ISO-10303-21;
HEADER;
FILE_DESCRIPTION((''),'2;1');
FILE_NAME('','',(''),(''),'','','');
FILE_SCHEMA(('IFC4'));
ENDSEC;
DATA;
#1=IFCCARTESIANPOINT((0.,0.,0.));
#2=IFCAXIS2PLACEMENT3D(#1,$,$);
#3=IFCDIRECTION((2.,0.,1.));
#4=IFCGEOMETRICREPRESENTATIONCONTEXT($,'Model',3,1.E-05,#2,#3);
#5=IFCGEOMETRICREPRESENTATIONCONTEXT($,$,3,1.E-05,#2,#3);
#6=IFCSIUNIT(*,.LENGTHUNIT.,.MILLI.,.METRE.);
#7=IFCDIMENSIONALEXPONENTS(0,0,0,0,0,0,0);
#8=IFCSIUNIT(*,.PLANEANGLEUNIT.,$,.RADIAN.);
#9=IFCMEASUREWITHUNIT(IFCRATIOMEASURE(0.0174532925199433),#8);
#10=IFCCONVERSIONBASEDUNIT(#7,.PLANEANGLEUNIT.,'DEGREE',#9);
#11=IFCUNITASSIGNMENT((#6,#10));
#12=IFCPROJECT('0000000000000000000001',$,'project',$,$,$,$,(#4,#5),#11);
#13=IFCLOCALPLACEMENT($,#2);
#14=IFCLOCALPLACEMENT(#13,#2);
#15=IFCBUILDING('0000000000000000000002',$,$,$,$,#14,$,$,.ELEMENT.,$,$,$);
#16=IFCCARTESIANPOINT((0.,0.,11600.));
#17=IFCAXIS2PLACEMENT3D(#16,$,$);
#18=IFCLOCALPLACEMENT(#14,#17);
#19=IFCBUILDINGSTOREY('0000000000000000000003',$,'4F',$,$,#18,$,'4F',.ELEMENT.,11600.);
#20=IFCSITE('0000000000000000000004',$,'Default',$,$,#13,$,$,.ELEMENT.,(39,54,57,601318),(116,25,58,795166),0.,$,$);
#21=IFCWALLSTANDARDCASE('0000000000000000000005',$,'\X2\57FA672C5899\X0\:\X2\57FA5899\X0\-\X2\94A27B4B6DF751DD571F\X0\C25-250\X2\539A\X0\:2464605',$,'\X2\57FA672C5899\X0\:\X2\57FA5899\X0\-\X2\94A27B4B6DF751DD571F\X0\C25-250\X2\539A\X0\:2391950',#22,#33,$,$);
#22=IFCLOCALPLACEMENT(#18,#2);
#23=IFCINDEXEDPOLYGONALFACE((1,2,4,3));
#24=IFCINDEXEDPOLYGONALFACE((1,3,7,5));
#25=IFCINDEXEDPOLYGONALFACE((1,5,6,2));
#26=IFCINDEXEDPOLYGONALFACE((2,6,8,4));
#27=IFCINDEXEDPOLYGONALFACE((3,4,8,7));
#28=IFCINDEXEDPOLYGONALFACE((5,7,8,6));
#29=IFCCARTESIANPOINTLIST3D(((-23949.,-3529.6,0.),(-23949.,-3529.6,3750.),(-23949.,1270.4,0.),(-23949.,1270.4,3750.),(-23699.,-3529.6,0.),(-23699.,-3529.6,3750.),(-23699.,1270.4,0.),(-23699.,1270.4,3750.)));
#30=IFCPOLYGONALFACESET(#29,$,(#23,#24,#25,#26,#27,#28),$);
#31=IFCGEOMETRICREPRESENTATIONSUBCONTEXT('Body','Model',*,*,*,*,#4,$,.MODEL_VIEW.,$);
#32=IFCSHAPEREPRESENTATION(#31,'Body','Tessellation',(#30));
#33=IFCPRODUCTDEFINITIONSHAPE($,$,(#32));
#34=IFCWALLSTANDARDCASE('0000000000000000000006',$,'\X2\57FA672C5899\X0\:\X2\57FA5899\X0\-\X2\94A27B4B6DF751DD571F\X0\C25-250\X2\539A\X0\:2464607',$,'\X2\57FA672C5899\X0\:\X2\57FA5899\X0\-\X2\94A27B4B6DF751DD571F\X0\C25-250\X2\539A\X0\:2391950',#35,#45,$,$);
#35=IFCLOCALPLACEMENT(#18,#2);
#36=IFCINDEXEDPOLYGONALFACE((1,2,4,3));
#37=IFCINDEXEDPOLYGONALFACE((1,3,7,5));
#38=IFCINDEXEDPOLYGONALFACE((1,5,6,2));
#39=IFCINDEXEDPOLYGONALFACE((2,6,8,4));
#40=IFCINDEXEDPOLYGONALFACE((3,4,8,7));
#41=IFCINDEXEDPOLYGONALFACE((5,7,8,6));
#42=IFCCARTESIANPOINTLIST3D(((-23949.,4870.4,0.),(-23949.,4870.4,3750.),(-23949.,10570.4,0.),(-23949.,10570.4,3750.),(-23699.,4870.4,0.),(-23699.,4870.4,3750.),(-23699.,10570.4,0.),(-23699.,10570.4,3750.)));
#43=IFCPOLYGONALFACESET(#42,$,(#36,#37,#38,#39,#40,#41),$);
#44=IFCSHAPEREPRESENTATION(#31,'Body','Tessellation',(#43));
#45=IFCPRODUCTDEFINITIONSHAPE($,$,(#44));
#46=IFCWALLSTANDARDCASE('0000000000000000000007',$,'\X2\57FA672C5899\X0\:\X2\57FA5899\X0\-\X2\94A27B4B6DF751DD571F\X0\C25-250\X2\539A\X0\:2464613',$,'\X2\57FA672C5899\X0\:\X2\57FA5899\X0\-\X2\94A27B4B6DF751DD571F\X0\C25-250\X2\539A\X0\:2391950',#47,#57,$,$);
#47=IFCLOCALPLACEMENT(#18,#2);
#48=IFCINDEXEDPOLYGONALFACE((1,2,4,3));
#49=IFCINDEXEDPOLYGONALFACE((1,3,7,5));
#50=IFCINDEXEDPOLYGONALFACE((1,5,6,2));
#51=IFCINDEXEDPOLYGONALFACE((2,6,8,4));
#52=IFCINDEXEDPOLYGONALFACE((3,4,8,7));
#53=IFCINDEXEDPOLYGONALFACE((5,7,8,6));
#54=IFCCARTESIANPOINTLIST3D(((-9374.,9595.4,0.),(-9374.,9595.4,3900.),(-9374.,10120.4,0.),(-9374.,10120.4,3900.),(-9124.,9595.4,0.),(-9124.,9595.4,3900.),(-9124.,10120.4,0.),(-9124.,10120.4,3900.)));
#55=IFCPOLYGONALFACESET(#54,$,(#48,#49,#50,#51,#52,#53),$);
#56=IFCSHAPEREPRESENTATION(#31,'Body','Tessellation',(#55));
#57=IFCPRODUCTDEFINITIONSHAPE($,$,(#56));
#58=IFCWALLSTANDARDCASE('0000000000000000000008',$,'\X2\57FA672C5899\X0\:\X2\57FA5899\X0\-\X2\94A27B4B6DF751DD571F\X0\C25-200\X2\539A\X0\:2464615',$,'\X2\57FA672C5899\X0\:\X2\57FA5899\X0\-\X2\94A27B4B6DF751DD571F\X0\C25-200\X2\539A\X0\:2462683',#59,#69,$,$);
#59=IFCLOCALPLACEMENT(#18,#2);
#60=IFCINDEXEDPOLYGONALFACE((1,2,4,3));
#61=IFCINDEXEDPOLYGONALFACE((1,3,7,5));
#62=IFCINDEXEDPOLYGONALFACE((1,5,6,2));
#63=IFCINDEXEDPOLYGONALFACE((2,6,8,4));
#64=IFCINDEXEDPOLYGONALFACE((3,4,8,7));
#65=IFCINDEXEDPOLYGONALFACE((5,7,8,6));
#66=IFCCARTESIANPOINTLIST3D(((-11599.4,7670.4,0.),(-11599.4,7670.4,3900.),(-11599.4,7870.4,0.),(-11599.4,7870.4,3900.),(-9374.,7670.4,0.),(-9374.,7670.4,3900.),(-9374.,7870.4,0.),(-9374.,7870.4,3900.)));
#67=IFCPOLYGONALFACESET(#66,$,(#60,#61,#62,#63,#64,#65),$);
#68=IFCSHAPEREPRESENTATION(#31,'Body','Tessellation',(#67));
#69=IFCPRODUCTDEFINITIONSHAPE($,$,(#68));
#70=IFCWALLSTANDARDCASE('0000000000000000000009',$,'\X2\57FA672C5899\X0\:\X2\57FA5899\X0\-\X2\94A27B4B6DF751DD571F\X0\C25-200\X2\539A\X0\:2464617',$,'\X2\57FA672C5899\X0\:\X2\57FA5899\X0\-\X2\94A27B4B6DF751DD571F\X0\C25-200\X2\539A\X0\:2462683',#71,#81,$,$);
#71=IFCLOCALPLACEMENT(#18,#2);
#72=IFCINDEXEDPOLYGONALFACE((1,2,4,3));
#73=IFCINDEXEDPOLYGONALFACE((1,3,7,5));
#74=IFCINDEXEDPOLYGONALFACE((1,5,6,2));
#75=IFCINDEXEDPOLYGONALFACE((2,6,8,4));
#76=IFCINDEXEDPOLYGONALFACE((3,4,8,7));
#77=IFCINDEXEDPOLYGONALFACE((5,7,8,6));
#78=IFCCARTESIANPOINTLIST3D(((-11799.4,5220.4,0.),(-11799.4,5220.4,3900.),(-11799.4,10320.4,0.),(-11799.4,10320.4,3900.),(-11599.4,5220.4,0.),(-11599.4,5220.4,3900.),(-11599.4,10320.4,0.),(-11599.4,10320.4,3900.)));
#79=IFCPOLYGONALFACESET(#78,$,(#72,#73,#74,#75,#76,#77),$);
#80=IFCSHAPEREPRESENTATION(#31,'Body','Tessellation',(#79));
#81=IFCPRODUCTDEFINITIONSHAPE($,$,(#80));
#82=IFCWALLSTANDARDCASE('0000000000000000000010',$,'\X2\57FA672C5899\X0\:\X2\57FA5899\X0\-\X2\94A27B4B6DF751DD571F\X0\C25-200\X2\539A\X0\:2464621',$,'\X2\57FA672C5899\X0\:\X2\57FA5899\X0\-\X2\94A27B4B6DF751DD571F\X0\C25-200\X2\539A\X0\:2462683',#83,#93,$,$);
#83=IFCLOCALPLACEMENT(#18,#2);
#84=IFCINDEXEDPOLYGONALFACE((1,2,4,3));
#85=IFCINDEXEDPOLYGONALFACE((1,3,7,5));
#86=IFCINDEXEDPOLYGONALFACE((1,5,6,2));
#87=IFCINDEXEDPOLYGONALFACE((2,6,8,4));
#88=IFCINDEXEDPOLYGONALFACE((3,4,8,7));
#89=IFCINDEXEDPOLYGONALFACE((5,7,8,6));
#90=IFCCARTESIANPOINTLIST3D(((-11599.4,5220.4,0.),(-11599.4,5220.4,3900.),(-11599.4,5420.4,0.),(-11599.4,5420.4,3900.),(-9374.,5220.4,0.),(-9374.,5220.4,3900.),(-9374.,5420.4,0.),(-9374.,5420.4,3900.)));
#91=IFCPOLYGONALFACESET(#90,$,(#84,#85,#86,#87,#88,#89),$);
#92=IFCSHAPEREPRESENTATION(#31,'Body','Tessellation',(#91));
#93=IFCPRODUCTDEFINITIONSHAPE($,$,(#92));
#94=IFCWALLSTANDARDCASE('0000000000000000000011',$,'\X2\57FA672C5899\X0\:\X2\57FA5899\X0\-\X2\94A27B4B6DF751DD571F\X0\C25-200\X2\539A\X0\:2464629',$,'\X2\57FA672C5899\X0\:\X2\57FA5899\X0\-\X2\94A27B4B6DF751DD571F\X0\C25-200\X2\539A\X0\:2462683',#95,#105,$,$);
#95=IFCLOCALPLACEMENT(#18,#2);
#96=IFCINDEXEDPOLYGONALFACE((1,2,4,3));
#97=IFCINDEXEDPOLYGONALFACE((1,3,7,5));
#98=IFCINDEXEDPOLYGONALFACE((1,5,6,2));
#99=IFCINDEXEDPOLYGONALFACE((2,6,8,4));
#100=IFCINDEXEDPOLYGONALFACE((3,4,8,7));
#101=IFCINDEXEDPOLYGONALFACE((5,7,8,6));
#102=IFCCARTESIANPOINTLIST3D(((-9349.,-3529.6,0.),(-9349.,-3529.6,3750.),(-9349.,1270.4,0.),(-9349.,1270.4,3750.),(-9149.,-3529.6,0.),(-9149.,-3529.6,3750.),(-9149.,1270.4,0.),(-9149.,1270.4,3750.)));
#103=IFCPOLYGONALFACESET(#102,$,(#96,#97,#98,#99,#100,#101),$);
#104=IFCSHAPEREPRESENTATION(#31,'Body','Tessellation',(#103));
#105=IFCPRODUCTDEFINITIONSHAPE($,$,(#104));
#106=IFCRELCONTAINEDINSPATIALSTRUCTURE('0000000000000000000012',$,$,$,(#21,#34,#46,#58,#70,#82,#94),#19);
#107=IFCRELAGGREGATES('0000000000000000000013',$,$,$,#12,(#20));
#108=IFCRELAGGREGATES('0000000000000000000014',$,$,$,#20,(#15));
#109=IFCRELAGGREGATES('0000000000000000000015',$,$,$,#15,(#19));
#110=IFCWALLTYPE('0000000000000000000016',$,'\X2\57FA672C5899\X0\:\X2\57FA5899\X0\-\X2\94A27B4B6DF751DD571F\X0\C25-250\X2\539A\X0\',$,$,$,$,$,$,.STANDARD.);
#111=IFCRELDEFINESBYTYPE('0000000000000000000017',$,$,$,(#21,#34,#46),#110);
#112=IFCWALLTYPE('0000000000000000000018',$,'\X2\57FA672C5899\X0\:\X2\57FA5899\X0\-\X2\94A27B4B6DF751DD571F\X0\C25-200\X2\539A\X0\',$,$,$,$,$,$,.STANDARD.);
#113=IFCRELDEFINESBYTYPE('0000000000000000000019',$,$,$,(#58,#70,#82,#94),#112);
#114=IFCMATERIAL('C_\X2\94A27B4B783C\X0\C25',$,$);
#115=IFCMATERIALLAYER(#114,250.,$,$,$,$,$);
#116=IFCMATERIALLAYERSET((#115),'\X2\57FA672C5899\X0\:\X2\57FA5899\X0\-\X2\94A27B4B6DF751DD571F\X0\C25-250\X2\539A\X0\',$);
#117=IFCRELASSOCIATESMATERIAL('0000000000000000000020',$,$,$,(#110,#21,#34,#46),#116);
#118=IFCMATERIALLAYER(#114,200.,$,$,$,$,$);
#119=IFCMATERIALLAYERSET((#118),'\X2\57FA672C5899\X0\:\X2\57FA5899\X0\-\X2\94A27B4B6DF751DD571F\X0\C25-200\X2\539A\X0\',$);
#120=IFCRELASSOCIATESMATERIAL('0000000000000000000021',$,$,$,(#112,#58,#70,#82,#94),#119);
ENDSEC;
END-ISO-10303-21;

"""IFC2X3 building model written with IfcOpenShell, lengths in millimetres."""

from ifc_helpers import new_model, entity, si_unit, converted_unit, direction, frame, frame_2d, origin, place, context, subcontext, project, spatial, polyline, rectangle, extrude, clip, bounded_halfspace, material, layer, layer_set, layer_usage, type_object, element, save


model = new_model("IFC2X3")

# Units and contexts
model_context = context("Model", 3, precision=1e-05, world=origin(), true_north=direction((2.0, 0.0, 1.0)))
context_of_model = context(None, 3, precision=1e-05, world=origin(), true_north=direction((2.0, 0.0, 1.0)))
body_context = subcontext(model_context, "Body", "Model", "MODEL_VIEW")
ifc_project = project(units=[si_unit("LENGTHUNIT", "METRE", prefix="MILLI"), converted_unit("PLANEANGLEUNIT", "DEGREE", entity("IfcRatioMeasure", 0.0174532925199433), si_unit("PLANEANGLEUNIT", "RADIAN"), dimensions=[0, 0, 0, 0, 0, 0, 0])], contexts=[model_context, context_of_model])

# Site, building, storey
site_placement = place(None, origin())
site = spatial("IfcSite", under=ifc_project, at=site_placement, Name="Default", CompositionType="ELEMENT", RefLatitude=(39, 54, 57, 601318), RefLongitude=(116, 25, 58, 795166), RefElevation=0.0)
building_placement = place(site_placement, origin())
building = spatial("IfcBuilding", under=site, at=building_placement, CompositionType="ELEMENT")
storey_placement = place(building_placement, frame((0.0, 0.0, 11600.0)))
storey = spatial("IfcBuildingStorey", under=building, at=storey_placement, Name="4F", LongName="4F", CompositionType="ELEMENT", Elevation=11600.0)

# Shared definitions
ifc_material = material(Name="C_钢筋砼C25")

# Walls
ifc_layer_1 = layer(ifc_material, 250.0)
ifc_layer_set_1 = layer_set([ifc_layer_1], Name="基本墙:基墙-钢筋混凝土C25-250厚")
ifc_layer_usage_1 = layer_usage(ifc_layer_set_1, "AXIS2", "NEGATIVE", 125.0)
wall_type_1 = type_object("IfcWallType", Name="基本墙:基墙-钢筋混凝土C25-250厚", PredefinedType="STANDARD", material=ifc_layer_set_1)
wall_1_placement = place(storey_placement, frame((-23824.0, -3529.6, 0.0), z_axis=(0.0, 0.0, 1.0), x_axis=(0.0, 1.0, 0.0)))
element("IfcWallStandardCase", 1, at=wall_1_placement, inside=storey, type_object=wall_type_1, material=ifc_layer_usage_1, Name="基本墙:基墙-钢筋混凝土C25-250厚:2464605", ObjectType="基本墙:基墙-钢筋混凝土C25-250厚:2391950", context=body_context, shape_type="Clipping", body=[
    clip(clip(clip(extrude(rectangle(XDim=4800.0, YDim=250.0, at=frame_2d((2400.0, 0.0), x_axis=(-1.0, 0.0))), origin(), (0.0, 0.0, 1.0), 3900.0), bounded_halfspace(frame((4800.0, -125.0, 0.0), z_axis=(-1.0, 0.0, 0.0), x_axis=(0.0, 0.0, -1.0)), True, frame((4800.0, -125.0, 0.0), z_axis=(-1.0, 0.0, 0.0), x_axis=(0.0, 0.0, -1.0)), polyline([(0.0, 0.0), (-3750.0, 0.0), (-3750.0, -250.0), (0.0, -250.0), (0.0, 0.0)]))), bounded_halfspace(frame((0.0, 125.0, 0.0), z_axis=(-1.0, 0.0, 0.0), x_axis=(0.0, 0.0, -1.0)), False, frame((0.0, 125.0, 0.0), z_axis=(-1.0, 0.0, 0.0), x_axis=(0.0, 0.0, -1.0)), polyline([(0.0, 0.0), (0.0, 250.0), (-3750.0, 250.0), (-3750.0, 0.0), (0.0, 0.0)]))), bounded_halfspace(frame((0.0, -125.0, 3750.0), z_axis=(0.0, 0.0, -1.0), x_axis=(1.0, 0.0, 0.0)), True, frame((0.0, -125.0, 3750.0), z_axis=(0.0, 0.0, -1.0), x_axis=(1.0, 0.0, 0.0)), polyline([(0.0, 0.0), (0.0, -250.0), (4800.0, -250.0), (4800.0, 0.0), (0.0, 0.0)]))),
])
ifc_layer_usage_2 = layer_usage(ifc_layer_set_1, "AXIS2", "NEGATIVE", 125.0)
wall_2_placement = place(storey_placement, frame((-23824.0, 4870.4, 0.0), z_axis=(0.0, 0.0, 1.0), x_axis=(0.0, 1.0, 0.0)))
element("IfcWallStandardCase", 2, at=wall_2_placement, inside=storey, type_object=wall_type_1, material=ifc_layer_usage_2, Name="基本墙:基墙-钢筋混凝土C25-250厚:2464607", ObjectType="基本墙:基墙-钢筋混凝土C25-250厚:2391950", context=body_context, shape_type="Clipping", body=[
    clip(clip(clip(extrude(rectangle(XDim=5700.0, YDim=250.0, at=frame_2d((2850.0, 0.0), x_axis=(-1.0, 0.0))), origin(), (0.0, 0.0, 1.0), 3900.0), bounded_halfspace(frame((5700.0, -125.0, 0.0), z_axis=(-1.0, 0.0, 0.0), x_axis=(0.0, 0.0, -1.0)), True, frame((5700.0, -125.0, 0.0), z_axis=(-1.0, 0.0, 0.0), x_axis=(0.0, 0.0, -1.0)), polyline([(0.0, 0.0), (-3750.0, 0.0), (-3750.0, -250.0), (0.0, -250.0), (0.0, 0.0)]))), bounded_halfspace(frame((0.0, 125.0, 0.0), z_axis=(1.0, 0.0, 0.0), x_axis=(0.0, 0.0, -1.0)), True, frame((0.0, 125.0, 0.0), z_axis=(1.0, 0.0, 0.0), x_axis=(0.0, 0.0, -1.0)), polyline([(0.0, 0.0), (-3750.0, 0.0), (-3750.0, -250.0), (0.0, -250.0), (0.0, 0.0)]))), bounded_halfspace(frame((0.0, -125.0, 3750.0), z_axis=(0.0, 0.0, -1.0), x_axis=(1.0, 0.0, 0.0)), True, frame((0.0, -125.0, 3750.0), z_axis=(0.0, 0.0, -1.0), x_axis=(1.0, 0.0, 0.0)), polyline([(0.0, 0.0), (0.0, -250.0), (5700.0, -250.0), (5700.0, 0.0), (0.0, 0.0)]))),
])
ifc_layer_usage_3 = layer_usage(ifc_layer_set_1, "AXIS2", "NEGATIVE", 125.0)
wall_3_placement = place(storey_placement, frame((-9249.0, 10120.4, 0.0), z_axis=(0.0, 0.0, 1.0), x_axis=(0.0, -1.0, 0.0)))
element("IfcWallStandardCase", 3, at=wall_3_placement, inside=storey, type_object=wall_type_1, material=ifc_layer_usage_3, Name="基本墙:基墙-钢筋混凝土C25-250厚:2464613", ObjectType="基本墙:基墙-钢筋混凝土C25-250厚:2391950", context=body_context, shape_type="SweptSolid", body=[
    extrude(rectangle(XDim=525.0, YDim=250.0, at=frame_2d((262.5, 0.0), x_axis=(-1.0, 0.0))), origin(), (0.0, 0.0, 1.0), 3900.0),
])
ifc_layer_2 = layer(ifc_material, 200.0)
ifc_layer_set_2 = layer_set([ifc_layer_2], Name="基本墙:基墙-钢筋混凝土C25-200厚")
ifc_layer_usage_4 = layer_usage(ifc_layer_set_2, "AXIS2", "NEGATIVE", 100.0)
wall_type_2 = type_object("IfcWallType", Name="基本墙:基墙-钢筋混凝土C25-200厚", PredefinedType="STANDARD", material=ifc_layer_set_2)
wall_4_placement = place(storey_placement, frame((-9374.0, 7770.4, 0.0), z_axis=(0.0, 0.0, 1.0), x_axis=(-1.0, 0.0, 0.0)))
element("IfcWallStandardCase", 4, at=wall_4_placement, inside=storey, type_object=wall_type_2, material=ifc_layer_usage_4, Name="基本墙:基墙-钢筋混凝土C25-200厚:2464615", ObjectType="基本墙:基墙-钢筋混凝土C25-200厚:2462683", context=body_context, shape_type="SweptSolid", body=[
    extrude(rectangle(XDim=2225.4, YDim=200.0, at=frame_2d((1112.7, 0.0), x_axis=(-1.0, 0.0))), origin(), (0.0, 0.0, 1.0), 3900.0),
])
ifc_layer_usage_5 = layer_usage(ifc_layer_set_2, "AXIS2", "NEGATIVE", 100.0)
wall_5_placement = place(storey_placement, frame((-11699.4, 10320.4, 0.0), z_axis=(0.0, 0.0, 1.0), x_axis=(0.0, -1.0, 0.0)))
element("IfcWallStandardCase", 5, at=wall_5_placement, inside=storey, type_object=wall_type_2, material=ifc_layer_usage_5, Name="基本墙:基墙-钢筋混凝土C25-200厚:2464617", ObjectType="基本墙:基墙-钢筋混凝土C25-200厚:2462683", context=body_context, shape_type="SweptSolid", body=[
    extrude(rectangle(XDim=5100.0, YDim=200.0, at=frame_2d((2550.0, 0.0), x_axis=(-1.0, 0.0))), origin(), (0.0, 0.0, 1.0), 3900.0),
])
ifc_layer_usage_6 = layer_usage(ifc_layer_set_2, "AXIS2", "NEGATIVE", 100.0)
wall_6_placement = place(storey_placement, frame((-9374.0, 5320.4, 0.0), z_axis=(0.0, 0.0, 1.0), x_axis=(-1.0, 0.0, 0.0)))
element("IfcWallStandardCase", 6, at=wall_6_placement, inside=storey, type_object=wall_type_2, material=ifc_layer_usage_6, Name="基本墙:基墙-钢筋混凝土C25-200厚:2464621", ObjectType="基本墙:基墙-钢筋混凝土C25-200厚:2462683", context=body_context, shape_type="SweptSolid", body=[
    extrude(rectangle(XDim=2225.4, YDim=200.0, at=frame_2d((1112.7, 0.0), x_axis=(-1.0, 0.0))), origin(), (0.0, 0.0, 1.0), 3900.0),
])
ifc_layer_usage_7 = layer_usage(ifc_layer_set_2, "AXIS2", "NEGATIVE", 100.0)
wall_7_placement = place(storey_placement, frame((-9249.0, 1270.4, 0.0), z_axis=(0.0, 0.0, 1.0), x_axis=(0.0, -1.0, 0.0)))
element("IfcWallStandardCase", 7, at=wall_7_placement, inside=storey, type_object=wall_type_2, material=ifc_layer_usage_7, Name="基本墙:基墙-钢筋混凝土C25-200厚:2464629", ObjectType="基本墙:基墙-钢筋混凝土C25-200厚:2462683", context=body_context, shape_type="Clipping", body=[
    clip(clip(clip(extrude(rectangle(XDim=4800.0, YDim=200.0, at=frame_2d((2400.0, 0.0), x_axis=(-1.0, 0.0))), origin(), (0.0, 0.0, 1.0), 3900.0), bounded_halfspace(frame((0.0, 100.0, 0.0), z_axis=(1.0, 0.0, 0.0), x_axis=(0.0, 0.0, -1.0)), True, frame((0.0, 100.0, 0.0), z_axis=(1.0, 0.0, 0.0), x_axis=(0.0, 0.0, -1.0)), polyline([(0.0, 0.0), (-3750.0, 0.0), (-3750.0, -200.0), (0.0, -200.0), (0.0, 0.0)]))), bounded_halfspace(frame((4800.0, -100.0, 0.0), z_axis=(-1.0, 0.0, 0.0), x_axis=(0.0, 0.0, -1.0)), True, frame((4800.0, -100.0, 0.0), z_axis=(-1.0, 0.0, 0.0), x_axis=(0.0, 0.0, -1.0)), polyline([(0.0, 0.0), (-3750.0, 0.0), (-3750.0, -200.0), (0.0, -200.0), (0.0, 0.0)]))), bounded_halfspace(frame((0.0, -100.0, 3750.0), z_axis=(0.0, 0.0, -1.0), x_axis=(-1.0, 0.0, 0.0)), True, frame((0.0, -100.0, 3750.0), z_axis=(0.0, 0.0, -1.0), x_axis=(-1.0, 0.0, 0.0)), polyline([(0.0, 0.0), (0.0, 200.0), (-4800.0, 200.0), (-4800.0, 0.0), (0.0, 0.0)]))),
])

save(model, "model.ifc")
